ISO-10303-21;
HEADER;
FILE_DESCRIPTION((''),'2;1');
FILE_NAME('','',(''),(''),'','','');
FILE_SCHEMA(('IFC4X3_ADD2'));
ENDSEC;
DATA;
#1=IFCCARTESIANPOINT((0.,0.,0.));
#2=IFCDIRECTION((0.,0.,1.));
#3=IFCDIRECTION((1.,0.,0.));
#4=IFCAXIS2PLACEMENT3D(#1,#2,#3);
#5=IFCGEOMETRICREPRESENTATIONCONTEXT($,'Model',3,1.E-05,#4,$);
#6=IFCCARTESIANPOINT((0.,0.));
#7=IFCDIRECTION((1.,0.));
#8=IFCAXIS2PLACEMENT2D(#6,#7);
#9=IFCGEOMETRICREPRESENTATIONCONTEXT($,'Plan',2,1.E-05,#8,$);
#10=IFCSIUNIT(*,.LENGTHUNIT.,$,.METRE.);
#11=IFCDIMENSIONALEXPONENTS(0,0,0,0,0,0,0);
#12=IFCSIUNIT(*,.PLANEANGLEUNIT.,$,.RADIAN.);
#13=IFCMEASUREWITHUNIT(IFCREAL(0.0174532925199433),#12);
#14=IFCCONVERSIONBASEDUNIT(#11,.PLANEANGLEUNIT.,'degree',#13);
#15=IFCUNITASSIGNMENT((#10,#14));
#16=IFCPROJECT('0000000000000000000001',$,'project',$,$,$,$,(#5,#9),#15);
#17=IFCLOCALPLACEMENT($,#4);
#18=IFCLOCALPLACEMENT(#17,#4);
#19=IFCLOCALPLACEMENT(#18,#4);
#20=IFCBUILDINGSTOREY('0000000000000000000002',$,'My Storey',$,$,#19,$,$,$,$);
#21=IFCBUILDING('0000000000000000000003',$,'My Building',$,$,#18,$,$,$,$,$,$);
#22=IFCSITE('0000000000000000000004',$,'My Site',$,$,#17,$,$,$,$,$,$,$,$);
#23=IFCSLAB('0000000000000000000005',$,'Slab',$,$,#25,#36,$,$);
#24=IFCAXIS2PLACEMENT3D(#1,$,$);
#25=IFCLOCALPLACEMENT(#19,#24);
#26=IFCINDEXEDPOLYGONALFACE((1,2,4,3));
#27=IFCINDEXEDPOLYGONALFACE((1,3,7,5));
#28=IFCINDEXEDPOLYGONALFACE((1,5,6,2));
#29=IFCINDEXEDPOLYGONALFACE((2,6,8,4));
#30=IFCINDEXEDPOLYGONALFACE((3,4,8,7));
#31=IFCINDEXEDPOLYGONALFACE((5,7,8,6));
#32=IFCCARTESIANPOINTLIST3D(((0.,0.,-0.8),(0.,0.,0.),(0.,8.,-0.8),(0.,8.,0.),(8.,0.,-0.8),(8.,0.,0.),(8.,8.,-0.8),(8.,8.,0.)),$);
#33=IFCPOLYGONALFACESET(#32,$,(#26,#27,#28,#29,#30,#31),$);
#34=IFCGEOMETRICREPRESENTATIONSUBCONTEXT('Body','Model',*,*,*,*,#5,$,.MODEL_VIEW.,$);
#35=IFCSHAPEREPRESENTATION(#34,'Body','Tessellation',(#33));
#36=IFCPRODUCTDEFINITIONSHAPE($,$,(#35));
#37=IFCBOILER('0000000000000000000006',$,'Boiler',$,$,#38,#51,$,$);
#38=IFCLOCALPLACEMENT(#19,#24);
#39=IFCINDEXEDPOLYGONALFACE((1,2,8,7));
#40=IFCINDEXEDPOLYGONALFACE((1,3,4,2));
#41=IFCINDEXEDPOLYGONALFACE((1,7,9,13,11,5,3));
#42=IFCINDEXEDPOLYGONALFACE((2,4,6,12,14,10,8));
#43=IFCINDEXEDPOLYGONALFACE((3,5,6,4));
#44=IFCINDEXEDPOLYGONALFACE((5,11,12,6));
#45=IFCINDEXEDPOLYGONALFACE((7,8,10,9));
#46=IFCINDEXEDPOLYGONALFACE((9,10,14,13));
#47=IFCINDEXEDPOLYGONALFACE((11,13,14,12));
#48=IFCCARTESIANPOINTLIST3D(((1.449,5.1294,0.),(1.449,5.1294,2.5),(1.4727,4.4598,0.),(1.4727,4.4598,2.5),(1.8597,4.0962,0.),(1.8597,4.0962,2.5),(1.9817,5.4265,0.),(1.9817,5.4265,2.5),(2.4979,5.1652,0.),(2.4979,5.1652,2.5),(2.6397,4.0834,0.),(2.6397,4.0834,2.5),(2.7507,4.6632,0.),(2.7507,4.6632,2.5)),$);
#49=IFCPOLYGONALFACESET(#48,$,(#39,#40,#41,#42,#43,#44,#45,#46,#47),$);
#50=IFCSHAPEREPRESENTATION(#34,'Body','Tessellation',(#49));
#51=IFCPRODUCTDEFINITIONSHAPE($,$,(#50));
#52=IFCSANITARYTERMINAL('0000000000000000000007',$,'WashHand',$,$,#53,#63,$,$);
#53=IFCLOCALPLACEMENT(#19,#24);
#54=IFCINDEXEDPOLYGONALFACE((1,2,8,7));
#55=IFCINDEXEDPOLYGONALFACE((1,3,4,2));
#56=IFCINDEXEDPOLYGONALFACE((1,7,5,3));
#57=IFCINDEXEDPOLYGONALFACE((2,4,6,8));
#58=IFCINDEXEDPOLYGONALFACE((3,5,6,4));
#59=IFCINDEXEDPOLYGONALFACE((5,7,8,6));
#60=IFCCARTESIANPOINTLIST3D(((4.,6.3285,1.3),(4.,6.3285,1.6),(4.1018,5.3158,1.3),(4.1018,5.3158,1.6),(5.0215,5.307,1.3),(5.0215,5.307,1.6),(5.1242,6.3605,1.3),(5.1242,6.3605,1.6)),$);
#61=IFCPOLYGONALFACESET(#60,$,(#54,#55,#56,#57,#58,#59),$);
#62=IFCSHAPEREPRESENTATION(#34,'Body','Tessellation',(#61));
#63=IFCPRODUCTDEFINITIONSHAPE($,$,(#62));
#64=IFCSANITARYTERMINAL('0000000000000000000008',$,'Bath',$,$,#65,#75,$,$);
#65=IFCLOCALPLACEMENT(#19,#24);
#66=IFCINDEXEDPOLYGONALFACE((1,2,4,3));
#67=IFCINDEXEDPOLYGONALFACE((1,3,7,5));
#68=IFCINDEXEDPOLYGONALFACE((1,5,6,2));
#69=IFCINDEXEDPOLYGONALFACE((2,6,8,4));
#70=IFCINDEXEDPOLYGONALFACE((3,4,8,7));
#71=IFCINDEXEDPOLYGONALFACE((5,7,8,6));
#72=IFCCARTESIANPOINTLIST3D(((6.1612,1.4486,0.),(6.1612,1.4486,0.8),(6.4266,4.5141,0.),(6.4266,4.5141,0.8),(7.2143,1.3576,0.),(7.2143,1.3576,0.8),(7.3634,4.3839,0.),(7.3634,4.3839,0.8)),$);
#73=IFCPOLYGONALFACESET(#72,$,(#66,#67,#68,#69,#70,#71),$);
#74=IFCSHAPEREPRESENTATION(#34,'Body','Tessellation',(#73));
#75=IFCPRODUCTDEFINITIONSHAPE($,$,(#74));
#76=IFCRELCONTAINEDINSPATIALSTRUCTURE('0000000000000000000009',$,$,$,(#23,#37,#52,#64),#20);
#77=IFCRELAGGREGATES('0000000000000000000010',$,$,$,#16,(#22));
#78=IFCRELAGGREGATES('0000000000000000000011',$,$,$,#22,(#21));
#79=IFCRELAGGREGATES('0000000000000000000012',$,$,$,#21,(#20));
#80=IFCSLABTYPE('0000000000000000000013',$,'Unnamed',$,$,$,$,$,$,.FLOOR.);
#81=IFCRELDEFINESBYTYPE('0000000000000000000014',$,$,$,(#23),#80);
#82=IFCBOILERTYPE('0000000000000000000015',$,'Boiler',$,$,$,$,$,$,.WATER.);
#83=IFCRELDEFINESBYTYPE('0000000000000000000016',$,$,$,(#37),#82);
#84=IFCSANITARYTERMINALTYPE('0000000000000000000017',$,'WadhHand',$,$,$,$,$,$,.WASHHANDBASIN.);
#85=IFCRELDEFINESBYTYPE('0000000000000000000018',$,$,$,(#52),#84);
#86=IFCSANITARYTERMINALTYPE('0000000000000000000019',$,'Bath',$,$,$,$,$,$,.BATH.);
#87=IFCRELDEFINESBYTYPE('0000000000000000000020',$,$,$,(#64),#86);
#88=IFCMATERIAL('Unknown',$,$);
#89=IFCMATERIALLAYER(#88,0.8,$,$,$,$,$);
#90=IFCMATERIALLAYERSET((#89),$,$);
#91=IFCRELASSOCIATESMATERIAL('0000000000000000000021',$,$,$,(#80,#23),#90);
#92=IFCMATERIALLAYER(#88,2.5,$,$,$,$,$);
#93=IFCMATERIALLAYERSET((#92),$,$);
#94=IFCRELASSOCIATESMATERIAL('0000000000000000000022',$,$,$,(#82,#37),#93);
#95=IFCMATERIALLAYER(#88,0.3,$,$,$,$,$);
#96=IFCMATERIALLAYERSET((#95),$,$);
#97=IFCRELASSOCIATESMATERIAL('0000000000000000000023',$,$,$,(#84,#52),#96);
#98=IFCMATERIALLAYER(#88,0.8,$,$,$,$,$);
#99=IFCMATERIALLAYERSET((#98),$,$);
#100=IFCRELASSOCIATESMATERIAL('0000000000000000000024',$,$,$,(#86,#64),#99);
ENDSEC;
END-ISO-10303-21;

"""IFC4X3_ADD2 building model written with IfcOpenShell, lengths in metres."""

from ifc_helpers import new_model, entity, si_unit, converted_unit, frame, origin_with_axes, origin_2d_with_axis, place, context, subcontext, project, spatial, indexed_curve, outline, extrude, material, layer, layer_set, layer_usage, type_object, element, save


model = new_model("IFC4X3_ADD2")

# Units and contexts
model_context = context("Model", 3, precision=1e-05, world=origin_with_axes())
plan_context = context("Plan", 2, precision=1e-05, world=origin_2d_with_axis())
body_context = subcontext(model_context, "Body", "Model", "MODEL_VIEW")
ifc_project = project(units=[si_unit("LENGTHUNIT", "METRE"), converted_unit("PLANEANGLEUNIT", "degree", entity("IfcReal", 0.0174532925199433), si_unit("PLANEANGLEUNIT", "RADIAN"), dimensions=[0, 0, 0, 0, 0, 0, 0])], contexts=[model_context, plan_context])

# Site, building, storey
site_placement = place(None, origin_with_axes())
site = spatial("IfcSite", under=ifc_project, at=site_placement, Name="My Site")
building_placement = place(site_placement, origin_with_axes())
building = spatial("IfcBuilding", under=site, at=building_placement, Name="My Building")
storey_placement = place(building_placement, origin_with_axes())
storey = spatial("IfcBuildingStorey", under=building, at=storey_placement, Name="My Storey")

# Slab
ifc_material = material(Name="Unknown")
ifc_layer_1 = layer(ifc_material, 0.8)
ifc_layer_set_1 = layer_set([ifc_layer_1])
ifc_layer_usage_1 = layer_usage(ifc_layer_set_1, "AXIS3", "POSITIVE", -0.8)
slab_type = type_object("IfcSlabType", Name="Unnamed", PredefinedType="FLOOR", material=ifc_layer_set_1)
slab_placement = place(storey_placement, origin_with_axes())
element("IfcSlab", 1, at=slab_placement, inside=storey, type_object=slab_type, material=ifc_layer_usage_1, Name="Slab", context=body_context, shape_type="SweptSolid", body=[
    extrude(outline(indexed_curve([(0.0, 0.0), (8.0, 0.0), (8.0, 8.0), (0.0, 8.0), (0.0, 0.0)])), frame((0.0, 0.0, -0.8), z_axis=(0.0, 0.0, 1.0), x_axis=(1.0, 0.0, 0.0)), (0.0, 0.0, 1.0), 0.8),
])

# Boiler
ifc_layer_2 = layer(ifc_material, 2.5)
ifc_layer_set_2 = layer_set([ifc_layer_2])
ifc_layer_usage_2 = layer_usage(ifc_layer_set_2, "AXIS3", "POSITIVE", 0.0)
boiler_type = type_object("IfcBoilerType", Name="Boiler", PredefinedType="WATER", material=ifc_layer_set_2)
boiler_placement = place(storey_placement, frame((1.4727, 4.4598, 0.0), z_axis=(0.0, 0.0, 1.0), x_axis=(1.0, 0.0, 0.0)))
element("IfcBoiler", 2, at=boiler_placement, inside=storey, type_object=boiler_type, material=ifc_layer_usage_2, Name="Boiler", context=body_context, shape_type="SweptSolid", body=[
    extrude(outline(indexed_curve([(0.0, 0.0), (0.387, -0.3636), (1.1671, -0.3764), (1.278, 0.2034), (1.0252, 0.7054), (0.5091, 0.9667), (-0.0237, 0.6696), (0.0, 0.0)])), None, (0.0, 0.0, 1.0), 2.5),
])

# Sanitary terminals
ifc_layer_3 = layer(ifc_material, 0.3)
ifc_layer_set_3 = layer_set([ifc_layer_3])
ifc_layer_usage_3 = layer_usage(ifc_layer_set_3, "AXIS3", "POSITIVE", 1.3)
sanitary_terminal_type_1 = type_object("IfcSanitaryTerminalType", Name="WadhHand", PredefinedType="WASHHANDBASIN", material=ifc_layer_set_3)
sanitary_terminal_1_placement = place(storey_placement, frame((4.1018, 5.3158, 0.0), z_axis=(0.0, 0.0, 1.0), x_axis=(1.0, 0.0, 0.0)))
element("IfcSanitaryTerminal", 3, at=sanitary_terminal_1_placement, inside=storey, type_object=sanitary_terminal_type_1, material=ifc_layer_usage_3, Name="WashHand", context=body_context, shape_type="SweptSolid", body=[
    extrude(outline(indexed_curve([(0.0, 0.0), (0.9197, -0.0087), (1.0224, 1.0447), (-0.1018, 1.0127), (0.0, 0.0)])), frame((0.0, 0.0, 1.3), z_axis=(0.0, 0.0, 1.0), x_axis=(1.0, 0.0, 0.0)), (0.0, 0.0, 1.0), 0.3),
])
ifc_layer_4 = layer(ifc_material, 0.8)
ifc_layer_set_4 = layer_set([ifc_layer_4])
ifc_layer_usage_4 = layer_usage(ifc_layer_set_4, "AXIS3", "POSITIVE", 0.0)
sanitary_terminal_type_2 = type_object("IfcSanitaryTerminalType", Name="Bath", PredefinedType="BATH", material=ifc_layer_set_4)
sanitary_terminal_2_placement = place(storey_placement, frame((6.1612, 1.4486, 0.0), z_axis=(0.0, 0.0, 1.0), x_axis=(1.0, 0.0, 0.0)))
element("IfcSanitaryTerminal", 4, at=sanitary_terminal_2_placement, inside=storey, type_object=sanitary_terminal_type_2, material=ifc_layer_usage_4, Name="Bath", context=body_context, shape_type="SweptSolid", body=[
    extrude(outline(indexed_curve([(0.0, 0.0), (1.053, -0.091), (1.2022, 2.9353), (0.2653, 3.0655), (0.0, 0.0)])), None, (0.0, 0.0, 1.0), 0.8),
])

save(model, "model.ifc")
